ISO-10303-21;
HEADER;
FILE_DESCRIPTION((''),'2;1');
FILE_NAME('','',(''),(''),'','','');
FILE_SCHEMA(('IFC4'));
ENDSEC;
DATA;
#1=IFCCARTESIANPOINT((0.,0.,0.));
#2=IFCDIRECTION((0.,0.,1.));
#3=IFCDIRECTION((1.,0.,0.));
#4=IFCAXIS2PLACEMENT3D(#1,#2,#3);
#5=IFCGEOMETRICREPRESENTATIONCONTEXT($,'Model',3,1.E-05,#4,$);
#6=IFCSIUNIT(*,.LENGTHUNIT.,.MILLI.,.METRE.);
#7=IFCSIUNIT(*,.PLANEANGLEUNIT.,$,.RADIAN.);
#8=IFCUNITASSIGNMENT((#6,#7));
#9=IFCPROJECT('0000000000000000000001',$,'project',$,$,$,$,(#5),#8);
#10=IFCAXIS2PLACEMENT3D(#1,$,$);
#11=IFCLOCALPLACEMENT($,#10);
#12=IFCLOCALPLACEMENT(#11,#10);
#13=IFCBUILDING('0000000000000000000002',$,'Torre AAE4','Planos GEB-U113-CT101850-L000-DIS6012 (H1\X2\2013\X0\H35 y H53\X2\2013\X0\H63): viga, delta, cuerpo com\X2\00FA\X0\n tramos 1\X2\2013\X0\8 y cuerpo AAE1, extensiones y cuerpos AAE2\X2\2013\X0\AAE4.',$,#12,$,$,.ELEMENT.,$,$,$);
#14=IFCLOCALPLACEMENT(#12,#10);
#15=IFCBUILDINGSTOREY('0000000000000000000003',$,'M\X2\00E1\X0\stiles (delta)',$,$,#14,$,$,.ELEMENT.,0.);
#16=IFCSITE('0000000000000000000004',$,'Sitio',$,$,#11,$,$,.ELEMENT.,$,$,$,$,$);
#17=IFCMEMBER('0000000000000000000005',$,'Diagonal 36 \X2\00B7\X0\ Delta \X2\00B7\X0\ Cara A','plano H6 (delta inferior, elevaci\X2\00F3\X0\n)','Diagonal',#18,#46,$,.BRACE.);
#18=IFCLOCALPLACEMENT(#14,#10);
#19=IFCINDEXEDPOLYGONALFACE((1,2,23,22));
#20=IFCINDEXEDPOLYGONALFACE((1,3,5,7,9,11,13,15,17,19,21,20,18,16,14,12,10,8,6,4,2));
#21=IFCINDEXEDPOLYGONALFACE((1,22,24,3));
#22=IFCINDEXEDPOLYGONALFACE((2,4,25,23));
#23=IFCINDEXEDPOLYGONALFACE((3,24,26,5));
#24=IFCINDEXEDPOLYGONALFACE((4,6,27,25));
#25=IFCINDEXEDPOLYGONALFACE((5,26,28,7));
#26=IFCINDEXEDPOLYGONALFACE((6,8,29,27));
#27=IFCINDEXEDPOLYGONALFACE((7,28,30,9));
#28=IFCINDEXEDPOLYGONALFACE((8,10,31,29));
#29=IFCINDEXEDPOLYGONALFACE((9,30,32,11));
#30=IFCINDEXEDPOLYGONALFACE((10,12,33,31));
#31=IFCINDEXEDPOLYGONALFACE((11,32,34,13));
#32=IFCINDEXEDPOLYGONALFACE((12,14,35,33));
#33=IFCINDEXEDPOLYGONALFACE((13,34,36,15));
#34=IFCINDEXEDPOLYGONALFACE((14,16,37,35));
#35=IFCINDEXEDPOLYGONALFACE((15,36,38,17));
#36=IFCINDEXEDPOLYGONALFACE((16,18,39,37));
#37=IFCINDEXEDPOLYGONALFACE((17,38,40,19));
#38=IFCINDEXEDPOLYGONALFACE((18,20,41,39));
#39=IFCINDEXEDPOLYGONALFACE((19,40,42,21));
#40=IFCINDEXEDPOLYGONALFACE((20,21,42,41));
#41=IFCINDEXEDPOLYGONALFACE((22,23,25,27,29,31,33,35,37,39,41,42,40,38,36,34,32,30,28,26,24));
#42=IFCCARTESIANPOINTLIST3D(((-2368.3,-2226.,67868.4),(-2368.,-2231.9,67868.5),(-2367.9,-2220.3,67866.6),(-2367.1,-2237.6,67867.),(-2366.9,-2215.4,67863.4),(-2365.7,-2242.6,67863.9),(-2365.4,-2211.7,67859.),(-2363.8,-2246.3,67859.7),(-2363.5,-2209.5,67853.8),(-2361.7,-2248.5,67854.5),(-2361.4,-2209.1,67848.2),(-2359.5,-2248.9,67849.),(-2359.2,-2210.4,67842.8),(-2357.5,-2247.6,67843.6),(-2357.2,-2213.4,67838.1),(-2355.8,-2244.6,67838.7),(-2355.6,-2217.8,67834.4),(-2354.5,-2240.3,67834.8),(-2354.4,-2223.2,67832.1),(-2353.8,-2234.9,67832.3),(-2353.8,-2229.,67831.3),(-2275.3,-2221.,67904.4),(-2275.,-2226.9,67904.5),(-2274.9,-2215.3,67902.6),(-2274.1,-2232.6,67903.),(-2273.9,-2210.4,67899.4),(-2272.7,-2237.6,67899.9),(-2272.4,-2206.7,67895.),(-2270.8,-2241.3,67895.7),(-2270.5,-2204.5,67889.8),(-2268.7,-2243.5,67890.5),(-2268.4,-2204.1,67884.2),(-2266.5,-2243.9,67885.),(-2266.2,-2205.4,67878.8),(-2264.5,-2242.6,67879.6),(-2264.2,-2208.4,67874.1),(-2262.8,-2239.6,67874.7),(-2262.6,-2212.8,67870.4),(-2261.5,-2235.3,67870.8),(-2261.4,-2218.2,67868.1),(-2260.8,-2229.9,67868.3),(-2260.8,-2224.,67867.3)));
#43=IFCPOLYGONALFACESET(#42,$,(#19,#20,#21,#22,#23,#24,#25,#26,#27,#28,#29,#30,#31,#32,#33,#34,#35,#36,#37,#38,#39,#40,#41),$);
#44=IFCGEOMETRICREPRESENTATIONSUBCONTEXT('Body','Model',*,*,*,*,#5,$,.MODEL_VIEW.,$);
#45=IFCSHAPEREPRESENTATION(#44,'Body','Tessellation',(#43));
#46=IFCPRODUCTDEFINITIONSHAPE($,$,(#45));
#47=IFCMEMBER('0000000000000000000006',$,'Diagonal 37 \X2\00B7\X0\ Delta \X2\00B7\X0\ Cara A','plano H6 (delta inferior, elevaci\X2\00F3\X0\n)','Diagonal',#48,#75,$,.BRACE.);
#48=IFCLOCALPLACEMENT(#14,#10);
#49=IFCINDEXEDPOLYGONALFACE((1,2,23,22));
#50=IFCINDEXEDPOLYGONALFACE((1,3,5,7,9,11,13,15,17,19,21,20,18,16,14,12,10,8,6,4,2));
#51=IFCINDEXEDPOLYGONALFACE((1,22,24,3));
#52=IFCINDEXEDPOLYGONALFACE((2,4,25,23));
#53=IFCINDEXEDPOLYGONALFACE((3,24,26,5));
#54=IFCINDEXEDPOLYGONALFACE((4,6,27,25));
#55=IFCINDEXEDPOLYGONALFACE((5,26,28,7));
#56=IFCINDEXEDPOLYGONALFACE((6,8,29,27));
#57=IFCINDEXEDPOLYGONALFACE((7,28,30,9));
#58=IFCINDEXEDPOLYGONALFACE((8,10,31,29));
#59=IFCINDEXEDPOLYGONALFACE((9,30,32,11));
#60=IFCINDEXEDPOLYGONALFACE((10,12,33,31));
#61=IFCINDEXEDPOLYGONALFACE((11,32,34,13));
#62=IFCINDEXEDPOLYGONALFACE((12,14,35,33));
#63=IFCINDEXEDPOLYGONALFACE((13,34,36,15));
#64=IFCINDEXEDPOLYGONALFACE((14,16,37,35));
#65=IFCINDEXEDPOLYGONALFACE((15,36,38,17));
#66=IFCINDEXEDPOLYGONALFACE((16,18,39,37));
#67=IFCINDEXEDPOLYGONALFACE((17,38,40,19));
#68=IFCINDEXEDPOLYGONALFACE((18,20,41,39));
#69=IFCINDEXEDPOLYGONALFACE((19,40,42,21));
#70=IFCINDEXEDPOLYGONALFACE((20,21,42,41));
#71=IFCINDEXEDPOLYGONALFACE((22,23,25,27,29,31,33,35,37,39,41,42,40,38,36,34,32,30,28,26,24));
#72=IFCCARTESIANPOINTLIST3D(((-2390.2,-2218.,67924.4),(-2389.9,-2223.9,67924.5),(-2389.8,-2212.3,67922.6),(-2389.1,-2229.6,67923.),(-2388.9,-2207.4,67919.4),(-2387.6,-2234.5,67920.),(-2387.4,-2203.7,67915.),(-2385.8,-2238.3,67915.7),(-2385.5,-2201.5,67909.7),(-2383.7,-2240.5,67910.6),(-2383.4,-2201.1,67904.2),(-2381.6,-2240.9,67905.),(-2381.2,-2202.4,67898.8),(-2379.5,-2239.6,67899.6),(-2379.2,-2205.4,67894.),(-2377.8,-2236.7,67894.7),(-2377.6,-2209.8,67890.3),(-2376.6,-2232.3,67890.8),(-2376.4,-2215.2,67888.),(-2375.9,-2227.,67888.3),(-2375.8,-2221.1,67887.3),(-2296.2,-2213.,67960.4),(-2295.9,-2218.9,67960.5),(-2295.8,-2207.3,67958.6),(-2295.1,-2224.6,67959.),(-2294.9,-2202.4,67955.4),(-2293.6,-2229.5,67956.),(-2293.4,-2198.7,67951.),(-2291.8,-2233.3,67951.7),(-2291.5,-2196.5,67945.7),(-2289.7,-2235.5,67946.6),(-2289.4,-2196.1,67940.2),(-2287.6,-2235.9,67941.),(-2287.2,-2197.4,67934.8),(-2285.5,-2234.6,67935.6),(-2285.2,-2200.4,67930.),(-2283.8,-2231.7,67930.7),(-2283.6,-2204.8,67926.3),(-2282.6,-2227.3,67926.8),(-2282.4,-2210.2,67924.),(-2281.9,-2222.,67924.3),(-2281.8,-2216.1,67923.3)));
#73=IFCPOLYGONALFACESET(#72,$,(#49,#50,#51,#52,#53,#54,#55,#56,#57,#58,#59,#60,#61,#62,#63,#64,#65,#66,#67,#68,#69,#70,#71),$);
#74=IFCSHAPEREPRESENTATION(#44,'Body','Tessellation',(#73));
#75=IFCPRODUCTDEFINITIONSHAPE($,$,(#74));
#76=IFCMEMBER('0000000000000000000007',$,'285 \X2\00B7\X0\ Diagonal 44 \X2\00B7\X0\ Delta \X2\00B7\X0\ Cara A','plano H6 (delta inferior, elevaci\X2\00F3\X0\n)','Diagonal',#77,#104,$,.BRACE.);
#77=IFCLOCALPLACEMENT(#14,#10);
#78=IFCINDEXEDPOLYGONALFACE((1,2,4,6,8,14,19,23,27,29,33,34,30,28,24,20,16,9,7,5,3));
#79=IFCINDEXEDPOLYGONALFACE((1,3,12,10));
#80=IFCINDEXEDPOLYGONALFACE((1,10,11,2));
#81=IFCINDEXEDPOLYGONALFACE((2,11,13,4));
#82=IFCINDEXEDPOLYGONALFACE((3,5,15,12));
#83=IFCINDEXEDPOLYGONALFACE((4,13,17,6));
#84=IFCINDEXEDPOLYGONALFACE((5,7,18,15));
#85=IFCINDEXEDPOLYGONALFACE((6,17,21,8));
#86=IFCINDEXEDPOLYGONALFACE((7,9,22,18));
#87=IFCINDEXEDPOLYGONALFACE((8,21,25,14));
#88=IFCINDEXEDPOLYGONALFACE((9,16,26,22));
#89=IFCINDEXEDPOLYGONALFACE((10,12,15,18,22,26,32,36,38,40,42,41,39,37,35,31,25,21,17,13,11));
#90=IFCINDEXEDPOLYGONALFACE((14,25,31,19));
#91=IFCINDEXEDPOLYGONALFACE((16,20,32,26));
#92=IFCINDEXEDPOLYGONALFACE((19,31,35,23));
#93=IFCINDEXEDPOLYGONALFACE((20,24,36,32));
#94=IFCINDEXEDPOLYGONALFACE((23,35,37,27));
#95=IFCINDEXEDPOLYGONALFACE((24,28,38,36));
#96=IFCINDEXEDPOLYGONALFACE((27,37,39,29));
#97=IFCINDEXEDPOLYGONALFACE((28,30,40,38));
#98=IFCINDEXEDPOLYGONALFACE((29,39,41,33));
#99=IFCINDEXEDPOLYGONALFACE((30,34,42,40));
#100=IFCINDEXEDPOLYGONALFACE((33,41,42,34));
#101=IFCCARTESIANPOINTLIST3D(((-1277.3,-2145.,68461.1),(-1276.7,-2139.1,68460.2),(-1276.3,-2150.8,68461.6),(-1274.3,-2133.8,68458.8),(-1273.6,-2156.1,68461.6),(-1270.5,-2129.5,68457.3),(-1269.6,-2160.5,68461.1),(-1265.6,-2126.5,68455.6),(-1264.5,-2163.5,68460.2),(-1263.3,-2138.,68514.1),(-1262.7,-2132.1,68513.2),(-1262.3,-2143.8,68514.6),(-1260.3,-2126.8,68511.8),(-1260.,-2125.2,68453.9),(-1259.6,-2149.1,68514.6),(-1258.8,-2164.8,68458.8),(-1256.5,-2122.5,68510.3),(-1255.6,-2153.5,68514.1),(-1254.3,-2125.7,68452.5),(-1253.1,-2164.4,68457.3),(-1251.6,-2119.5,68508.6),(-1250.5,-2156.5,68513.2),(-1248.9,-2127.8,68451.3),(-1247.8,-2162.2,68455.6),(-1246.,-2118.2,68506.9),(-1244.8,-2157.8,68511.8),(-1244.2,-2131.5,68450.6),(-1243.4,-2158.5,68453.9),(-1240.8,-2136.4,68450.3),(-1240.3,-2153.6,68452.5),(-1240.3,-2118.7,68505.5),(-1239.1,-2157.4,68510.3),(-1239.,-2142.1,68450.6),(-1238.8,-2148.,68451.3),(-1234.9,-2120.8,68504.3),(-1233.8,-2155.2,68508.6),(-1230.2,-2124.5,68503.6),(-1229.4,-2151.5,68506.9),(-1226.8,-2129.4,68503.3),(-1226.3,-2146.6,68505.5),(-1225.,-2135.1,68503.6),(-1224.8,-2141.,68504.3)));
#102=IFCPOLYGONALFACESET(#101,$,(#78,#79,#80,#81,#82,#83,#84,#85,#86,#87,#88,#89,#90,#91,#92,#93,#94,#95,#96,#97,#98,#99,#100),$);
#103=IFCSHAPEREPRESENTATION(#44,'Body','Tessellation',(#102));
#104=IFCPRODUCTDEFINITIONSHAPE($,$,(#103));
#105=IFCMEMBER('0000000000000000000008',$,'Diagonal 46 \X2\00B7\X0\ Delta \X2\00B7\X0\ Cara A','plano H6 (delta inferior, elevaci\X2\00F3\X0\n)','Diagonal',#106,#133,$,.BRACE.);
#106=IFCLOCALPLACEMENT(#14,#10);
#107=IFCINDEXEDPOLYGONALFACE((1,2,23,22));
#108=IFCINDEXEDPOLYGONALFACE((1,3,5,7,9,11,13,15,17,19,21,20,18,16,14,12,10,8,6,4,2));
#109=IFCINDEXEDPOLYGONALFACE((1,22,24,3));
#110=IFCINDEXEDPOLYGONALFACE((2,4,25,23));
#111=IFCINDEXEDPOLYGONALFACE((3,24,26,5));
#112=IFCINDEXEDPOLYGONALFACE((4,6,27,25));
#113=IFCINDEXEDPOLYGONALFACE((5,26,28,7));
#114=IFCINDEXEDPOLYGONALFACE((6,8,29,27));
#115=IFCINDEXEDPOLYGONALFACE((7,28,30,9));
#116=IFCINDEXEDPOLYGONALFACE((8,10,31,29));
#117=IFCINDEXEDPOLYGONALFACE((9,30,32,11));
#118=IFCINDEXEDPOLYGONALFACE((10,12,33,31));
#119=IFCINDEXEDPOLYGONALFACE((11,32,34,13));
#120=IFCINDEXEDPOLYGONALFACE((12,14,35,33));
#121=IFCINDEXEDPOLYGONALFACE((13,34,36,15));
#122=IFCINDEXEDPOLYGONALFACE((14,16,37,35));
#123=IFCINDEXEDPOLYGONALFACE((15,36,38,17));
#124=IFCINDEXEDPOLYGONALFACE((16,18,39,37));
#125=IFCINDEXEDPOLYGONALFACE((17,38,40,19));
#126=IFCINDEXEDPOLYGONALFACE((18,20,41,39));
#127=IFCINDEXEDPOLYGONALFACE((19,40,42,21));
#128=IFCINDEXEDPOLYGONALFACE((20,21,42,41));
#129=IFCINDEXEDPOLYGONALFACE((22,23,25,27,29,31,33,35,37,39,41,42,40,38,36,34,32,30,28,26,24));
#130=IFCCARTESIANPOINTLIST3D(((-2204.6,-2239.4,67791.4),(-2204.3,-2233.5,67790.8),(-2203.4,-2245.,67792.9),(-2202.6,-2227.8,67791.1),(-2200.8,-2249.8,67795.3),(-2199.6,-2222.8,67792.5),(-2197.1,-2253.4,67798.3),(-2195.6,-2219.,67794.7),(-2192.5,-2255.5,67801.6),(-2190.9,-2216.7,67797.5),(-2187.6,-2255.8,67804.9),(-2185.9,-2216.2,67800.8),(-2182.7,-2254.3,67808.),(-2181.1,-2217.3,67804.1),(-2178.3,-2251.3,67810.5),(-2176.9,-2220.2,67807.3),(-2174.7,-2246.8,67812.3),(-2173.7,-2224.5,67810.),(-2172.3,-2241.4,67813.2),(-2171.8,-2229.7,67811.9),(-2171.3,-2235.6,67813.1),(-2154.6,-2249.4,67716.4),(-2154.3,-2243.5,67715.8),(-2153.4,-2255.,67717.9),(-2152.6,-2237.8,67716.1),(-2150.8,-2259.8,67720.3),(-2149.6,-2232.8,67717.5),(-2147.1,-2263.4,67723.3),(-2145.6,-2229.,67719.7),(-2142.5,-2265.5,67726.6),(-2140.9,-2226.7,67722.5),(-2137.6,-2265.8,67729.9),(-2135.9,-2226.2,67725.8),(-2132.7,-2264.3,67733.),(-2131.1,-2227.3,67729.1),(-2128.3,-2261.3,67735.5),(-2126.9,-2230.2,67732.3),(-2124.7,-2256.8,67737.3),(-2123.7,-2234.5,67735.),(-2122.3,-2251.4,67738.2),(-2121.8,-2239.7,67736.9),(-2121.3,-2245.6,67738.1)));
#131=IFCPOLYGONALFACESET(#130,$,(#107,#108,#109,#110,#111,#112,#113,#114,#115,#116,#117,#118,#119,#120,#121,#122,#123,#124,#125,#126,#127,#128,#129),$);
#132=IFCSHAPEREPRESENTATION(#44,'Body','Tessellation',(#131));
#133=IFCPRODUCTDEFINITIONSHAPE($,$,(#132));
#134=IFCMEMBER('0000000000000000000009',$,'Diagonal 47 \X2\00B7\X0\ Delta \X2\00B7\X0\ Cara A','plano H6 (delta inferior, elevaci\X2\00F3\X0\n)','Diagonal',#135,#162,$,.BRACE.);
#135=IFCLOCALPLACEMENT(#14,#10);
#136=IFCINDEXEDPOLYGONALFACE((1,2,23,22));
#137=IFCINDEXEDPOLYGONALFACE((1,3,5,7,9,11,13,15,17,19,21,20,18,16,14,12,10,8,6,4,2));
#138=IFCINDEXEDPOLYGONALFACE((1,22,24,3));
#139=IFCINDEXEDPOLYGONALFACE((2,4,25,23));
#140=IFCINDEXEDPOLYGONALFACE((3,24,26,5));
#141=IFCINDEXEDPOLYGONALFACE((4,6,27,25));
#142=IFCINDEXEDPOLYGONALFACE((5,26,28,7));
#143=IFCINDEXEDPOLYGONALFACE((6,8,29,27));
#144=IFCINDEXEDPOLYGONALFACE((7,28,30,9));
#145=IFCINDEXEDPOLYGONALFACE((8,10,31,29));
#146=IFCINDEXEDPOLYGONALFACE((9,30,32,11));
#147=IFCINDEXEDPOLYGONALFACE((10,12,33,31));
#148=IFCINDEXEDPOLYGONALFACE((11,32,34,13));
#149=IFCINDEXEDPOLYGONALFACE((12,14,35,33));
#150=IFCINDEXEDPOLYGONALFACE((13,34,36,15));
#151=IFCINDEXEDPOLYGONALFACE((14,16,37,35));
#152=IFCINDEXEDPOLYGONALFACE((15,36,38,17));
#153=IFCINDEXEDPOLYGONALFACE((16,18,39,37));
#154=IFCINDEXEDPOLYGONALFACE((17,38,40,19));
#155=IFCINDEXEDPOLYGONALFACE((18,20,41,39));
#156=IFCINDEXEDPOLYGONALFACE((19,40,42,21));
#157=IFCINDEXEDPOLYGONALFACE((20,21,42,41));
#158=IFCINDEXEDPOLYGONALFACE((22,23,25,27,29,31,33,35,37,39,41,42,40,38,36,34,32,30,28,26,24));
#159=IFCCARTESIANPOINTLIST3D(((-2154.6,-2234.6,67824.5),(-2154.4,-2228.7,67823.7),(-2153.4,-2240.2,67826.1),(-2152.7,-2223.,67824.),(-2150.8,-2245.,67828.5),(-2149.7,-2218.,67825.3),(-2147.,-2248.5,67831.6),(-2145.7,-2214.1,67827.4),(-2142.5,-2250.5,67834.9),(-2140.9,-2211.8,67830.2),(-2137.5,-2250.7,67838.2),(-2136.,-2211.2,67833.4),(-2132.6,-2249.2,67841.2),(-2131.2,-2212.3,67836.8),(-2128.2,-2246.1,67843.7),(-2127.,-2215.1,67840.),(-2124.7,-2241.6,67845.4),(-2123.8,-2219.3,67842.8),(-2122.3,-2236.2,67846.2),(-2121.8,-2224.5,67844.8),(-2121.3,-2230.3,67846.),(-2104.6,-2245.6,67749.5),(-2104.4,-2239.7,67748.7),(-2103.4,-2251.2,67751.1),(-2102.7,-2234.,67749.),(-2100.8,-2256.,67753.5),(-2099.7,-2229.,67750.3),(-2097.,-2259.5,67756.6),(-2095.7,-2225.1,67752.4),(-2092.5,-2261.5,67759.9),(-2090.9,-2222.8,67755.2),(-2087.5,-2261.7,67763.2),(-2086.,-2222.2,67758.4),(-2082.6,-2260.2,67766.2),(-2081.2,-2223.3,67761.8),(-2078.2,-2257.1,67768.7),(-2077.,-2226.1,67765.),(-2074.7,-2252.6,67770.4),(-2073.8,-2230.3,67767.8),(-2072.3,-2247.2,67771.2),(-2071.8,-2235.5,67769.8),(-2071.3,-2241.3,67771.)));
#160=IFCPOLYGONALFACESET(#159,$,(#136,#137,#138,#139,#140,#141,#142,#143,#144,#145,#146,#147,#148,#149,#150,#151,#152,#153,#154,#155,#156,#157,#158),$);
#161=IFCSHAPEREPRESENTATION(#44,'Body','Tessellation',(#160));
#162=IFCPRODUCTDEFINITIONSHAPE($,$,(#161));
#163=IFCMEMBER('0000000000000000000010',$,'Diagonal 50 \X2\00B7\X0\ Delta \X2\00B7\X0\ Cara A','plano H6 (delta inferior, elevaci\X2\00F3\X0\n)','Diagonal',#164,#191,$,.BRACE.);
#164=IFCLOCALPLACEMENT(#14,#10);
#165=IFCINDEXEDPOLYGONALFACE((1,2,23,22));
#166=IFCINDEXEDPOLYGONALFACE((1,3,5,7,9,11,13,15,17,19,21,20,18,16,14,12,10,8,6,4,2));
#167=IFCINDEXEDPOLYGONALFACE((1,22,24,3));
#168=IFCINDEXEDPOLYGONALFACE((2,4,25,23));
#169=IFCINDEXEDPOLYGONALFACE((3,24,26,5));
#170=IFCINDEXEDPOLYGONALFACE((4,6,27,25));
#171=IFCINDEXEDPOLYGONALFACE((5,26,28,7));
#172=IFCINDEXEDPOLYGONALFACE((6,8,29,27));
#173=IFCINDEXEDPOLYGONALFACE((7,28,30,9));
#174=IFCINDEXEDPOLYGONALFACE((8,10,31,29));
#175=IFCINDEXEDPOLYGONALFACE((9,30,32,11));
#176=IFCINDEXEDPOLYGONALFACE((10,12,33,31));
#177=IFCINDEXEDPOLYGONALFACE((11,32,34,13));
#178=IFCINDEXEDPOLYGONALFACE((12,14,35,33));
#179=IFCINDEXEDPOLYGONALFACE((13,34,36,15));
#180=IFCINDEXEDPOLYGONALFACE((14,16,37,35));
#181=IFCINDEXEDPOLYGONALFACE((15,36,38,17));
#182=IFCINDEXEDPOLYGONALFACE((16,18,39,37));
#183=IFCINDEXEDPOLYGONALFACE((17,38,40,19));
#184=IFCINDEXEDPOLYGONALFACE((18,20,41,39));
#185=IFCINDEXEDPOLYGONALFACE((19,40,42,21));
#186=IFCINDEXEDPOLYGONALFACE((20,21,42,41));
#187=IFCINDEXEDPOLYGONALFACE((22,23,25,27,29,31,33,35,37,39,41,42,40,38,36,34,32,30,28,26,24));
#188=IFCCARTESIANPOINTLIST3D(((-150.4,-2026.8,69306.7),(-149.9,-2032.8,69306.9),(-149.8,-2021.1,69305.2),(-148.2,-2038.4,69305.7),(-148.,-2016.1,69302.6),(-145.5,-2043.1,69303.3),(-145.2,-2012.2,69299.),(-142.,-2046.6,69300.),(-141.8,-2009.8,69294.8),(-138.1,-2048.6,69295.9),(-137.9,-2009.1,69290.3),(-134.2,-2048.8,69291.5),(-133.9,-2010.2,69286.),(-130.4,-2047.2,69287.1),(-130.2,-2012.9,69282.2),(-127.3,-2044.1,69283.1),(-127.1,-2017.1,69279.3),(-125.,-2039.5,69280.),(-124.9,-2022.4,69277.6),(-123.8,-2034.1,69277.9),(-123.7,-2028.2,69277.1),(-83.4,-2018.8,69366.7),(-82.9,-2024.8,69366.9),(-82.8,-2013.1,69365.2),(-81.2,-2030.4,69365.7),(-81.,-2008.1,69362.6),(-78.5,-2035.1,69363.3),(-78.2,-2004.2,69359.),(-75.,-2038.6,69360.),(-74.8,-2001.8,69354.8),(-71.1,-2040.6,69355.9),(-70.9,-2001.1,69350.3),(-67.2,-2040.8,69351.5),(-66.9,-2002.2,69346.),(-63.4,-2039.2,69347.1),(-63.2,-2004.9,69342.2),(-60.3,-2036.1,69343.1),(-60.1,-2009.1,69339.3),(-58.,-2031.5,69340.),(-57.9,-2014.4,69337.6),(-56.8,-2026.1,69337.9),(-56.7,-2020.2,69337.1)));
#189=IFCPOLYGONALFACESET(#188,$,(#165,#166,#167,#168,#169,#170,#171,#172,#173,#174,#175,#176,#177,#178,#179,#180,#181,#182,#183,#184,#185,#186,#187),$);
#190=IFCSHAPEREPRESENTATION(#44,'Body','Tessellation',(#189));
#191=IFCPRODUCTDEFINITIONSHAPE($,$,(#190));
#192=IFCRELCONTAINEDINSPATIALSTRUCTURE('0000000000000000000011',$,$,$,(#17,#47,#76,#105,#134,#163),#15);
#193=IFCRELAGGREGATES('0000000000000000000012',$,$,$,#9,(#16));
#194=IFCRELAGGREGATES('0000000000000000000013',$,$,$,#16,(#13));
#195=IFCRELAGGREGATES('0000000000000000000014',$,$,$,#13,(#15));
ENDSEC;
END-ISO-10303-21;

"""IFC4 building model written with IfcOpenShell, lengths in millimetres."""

from ifc_helpers import new_model, si_unit, frame, origin, origin_with_axes, place, context, subcontext, project, spatial, circle, extrude, element, save


model = new_model("IFC4")

# Units and contexts
model_context = context("Model", 3, precision=1e-05, world=origin_with_axes())
body_context = subcontext(model_context, "Body", "Model", "MODEL_VIEW")
ifc_project = project(units=[si_unit("LENGTHUNIT", "METRE", prefix="MILLI"), si_unit("PLANEANGLEUNIT", "RADIAN")], contexts=[model_context])

# Site, building, storey
site_placement = place(None, origin())
site = spatial("IfcSite", under=ifc_project, at=site_placement, Name="Sitio", CompositionType="ELEMENT")
building_placement = place(site_placement, origin())
building = spatial("IfcBuilding", under=site, at=building_placement, Name="Torre AAE4", Description="Planos GEB-U113-CT101850-L000-DIS6012 (H1–H35 y H53–H63): viga, delta, cuerpo común tramos 1–8 y cuerpo AAE1, extensiones y cuerpos AAE2–AAE4.", CompositionType="ELEMENT")
storey_placement = place(building_placement, origin())
storey = spatial("IfcBuildingStorey", under=building, at=storey_placement, Name="Mástiles (delta)", CompositionType="ELEMENT", Elevation=0.0)

# Members
member_1_placement = place(storey_placement, frame((-2361.0, -2229.0, 67850.0), z_axis=(0.931398, 0.050075, 0.360541), x_axis=(0.089167, 0.928927, -0.359365)))
element("IfcMember", 1, at=member_1_placement, inside=storey, Name="Diagonal 36 · Delta · Cara A", Description="plano H6 (delta inferior, elevación)", ObjectType="Diagonal", PredefinedType="BRACE", context=body_context, shape_type="SweptSolid", body=[
    extrude(circle(Radius=20.0), None, (0.0, 0.0, 1.0), 99.8),
])
member_2_placement = place(storey_placement, frame((-2383.0, -2221.0, 67906.0), z_axis=(0.932707, 0.049612, 0.357207), x_axis=(0.088729, 0.928476, -0.360637)))
element("IfcMember", 2, at=member_2_placement, inside=storey, Name="Diagonal 37 · Delta · Cara A", Description="plano H6 (delta inferior, elevación)", ObjectType="Diagonal", PredefinedType="BRACE", context=body_context, shape_type="SweptSolid", body=[
    extrude(circle(Radius=20.0), None, (0.0, 0.0, 1.0), 100.8),
])
member_3_placement = place(storey_placement, frame((-1258.0, -2145.0, 68456.0), z_axis=(0.253334, 0.126667, 0.95905), x_axis=(0.457378, 0.857899, -0.234124)))
element("IfcMember", 3, at=member_3_placement, inside=storey, Name="285 · Diagonal 44 · Delta · Cara A", Description="plano H6 (delta inferior, elevación)", ObjectType="Diagonal", PredefinedType="BRACE", context=body_context, shape_type="SweptSolid", body=[
    extrude(circle(Radius=20.0), None, (0.0, 0.0, 1.0), 55.3),
])
member_4_placement = place(storey_placement, frame((-2138.0, -2246.0, 67727.0), z_axis=(-0.551318, 0.110264, 0.826977), x_axis=(0.553229, 0.790273, 0.26345)))
element("IfcMember", 4, at=member_4_placement, inside=storey, Name="Diagonal 46 · Delta · Cara A", Description="plano H6 (delta inferior, elevación)", ObjectType="Diagonal", PredefinedType="BRACE", context=body_context, shape_type="SweptSolid", body=[
    extrude(circle(Radius=20.0), None, (0.0, 0.0, 1.0), 90.7),
])
member_5_placement = place(storey_placement, frame((-2088.0, -2242.0, 67760.0), z_axis=(-0.550615, 0.121135, 0.825923), x_axis=(0.550707, 0.79627, 0.250352)))
element("IfcMember", 5, at=member_5_placement, inside=storey, Name="Diagonal 47 · Delta · Cara A", Description="plano H6 (delta inferior, elevación)", ObjectType="Diagonal", PredefinedType="BRACE", context=body_context, shape_type="SweptSolid", body=[
    extrude(circle(Radius=20.0), None, (0.0, 0.0, 1.0), 90.8),
])
member_6_placement = place(storey_placement, frame((-137.0, -2029.0, 69292.0), z_axis=(0.742021, 0.088599, 0.664496), x_axis=(-0.043062, 0.99548, -0.084644)))
element("IfcMember", 6, at=member_6_placement, inside=storey, Name="Diagonal 50 · Delta · Cara A", Description="plano H6 (delta inferior, elevación)", ObjectType="Diagonal", PredefinedType="BRACE", context=body_context, shape_type="SweptSolid", body=[
    extrude(circle(Radius=20.0), None, (0.0, 0.0, 1.0), 90.3),
])

save(model, "model.ifc")
